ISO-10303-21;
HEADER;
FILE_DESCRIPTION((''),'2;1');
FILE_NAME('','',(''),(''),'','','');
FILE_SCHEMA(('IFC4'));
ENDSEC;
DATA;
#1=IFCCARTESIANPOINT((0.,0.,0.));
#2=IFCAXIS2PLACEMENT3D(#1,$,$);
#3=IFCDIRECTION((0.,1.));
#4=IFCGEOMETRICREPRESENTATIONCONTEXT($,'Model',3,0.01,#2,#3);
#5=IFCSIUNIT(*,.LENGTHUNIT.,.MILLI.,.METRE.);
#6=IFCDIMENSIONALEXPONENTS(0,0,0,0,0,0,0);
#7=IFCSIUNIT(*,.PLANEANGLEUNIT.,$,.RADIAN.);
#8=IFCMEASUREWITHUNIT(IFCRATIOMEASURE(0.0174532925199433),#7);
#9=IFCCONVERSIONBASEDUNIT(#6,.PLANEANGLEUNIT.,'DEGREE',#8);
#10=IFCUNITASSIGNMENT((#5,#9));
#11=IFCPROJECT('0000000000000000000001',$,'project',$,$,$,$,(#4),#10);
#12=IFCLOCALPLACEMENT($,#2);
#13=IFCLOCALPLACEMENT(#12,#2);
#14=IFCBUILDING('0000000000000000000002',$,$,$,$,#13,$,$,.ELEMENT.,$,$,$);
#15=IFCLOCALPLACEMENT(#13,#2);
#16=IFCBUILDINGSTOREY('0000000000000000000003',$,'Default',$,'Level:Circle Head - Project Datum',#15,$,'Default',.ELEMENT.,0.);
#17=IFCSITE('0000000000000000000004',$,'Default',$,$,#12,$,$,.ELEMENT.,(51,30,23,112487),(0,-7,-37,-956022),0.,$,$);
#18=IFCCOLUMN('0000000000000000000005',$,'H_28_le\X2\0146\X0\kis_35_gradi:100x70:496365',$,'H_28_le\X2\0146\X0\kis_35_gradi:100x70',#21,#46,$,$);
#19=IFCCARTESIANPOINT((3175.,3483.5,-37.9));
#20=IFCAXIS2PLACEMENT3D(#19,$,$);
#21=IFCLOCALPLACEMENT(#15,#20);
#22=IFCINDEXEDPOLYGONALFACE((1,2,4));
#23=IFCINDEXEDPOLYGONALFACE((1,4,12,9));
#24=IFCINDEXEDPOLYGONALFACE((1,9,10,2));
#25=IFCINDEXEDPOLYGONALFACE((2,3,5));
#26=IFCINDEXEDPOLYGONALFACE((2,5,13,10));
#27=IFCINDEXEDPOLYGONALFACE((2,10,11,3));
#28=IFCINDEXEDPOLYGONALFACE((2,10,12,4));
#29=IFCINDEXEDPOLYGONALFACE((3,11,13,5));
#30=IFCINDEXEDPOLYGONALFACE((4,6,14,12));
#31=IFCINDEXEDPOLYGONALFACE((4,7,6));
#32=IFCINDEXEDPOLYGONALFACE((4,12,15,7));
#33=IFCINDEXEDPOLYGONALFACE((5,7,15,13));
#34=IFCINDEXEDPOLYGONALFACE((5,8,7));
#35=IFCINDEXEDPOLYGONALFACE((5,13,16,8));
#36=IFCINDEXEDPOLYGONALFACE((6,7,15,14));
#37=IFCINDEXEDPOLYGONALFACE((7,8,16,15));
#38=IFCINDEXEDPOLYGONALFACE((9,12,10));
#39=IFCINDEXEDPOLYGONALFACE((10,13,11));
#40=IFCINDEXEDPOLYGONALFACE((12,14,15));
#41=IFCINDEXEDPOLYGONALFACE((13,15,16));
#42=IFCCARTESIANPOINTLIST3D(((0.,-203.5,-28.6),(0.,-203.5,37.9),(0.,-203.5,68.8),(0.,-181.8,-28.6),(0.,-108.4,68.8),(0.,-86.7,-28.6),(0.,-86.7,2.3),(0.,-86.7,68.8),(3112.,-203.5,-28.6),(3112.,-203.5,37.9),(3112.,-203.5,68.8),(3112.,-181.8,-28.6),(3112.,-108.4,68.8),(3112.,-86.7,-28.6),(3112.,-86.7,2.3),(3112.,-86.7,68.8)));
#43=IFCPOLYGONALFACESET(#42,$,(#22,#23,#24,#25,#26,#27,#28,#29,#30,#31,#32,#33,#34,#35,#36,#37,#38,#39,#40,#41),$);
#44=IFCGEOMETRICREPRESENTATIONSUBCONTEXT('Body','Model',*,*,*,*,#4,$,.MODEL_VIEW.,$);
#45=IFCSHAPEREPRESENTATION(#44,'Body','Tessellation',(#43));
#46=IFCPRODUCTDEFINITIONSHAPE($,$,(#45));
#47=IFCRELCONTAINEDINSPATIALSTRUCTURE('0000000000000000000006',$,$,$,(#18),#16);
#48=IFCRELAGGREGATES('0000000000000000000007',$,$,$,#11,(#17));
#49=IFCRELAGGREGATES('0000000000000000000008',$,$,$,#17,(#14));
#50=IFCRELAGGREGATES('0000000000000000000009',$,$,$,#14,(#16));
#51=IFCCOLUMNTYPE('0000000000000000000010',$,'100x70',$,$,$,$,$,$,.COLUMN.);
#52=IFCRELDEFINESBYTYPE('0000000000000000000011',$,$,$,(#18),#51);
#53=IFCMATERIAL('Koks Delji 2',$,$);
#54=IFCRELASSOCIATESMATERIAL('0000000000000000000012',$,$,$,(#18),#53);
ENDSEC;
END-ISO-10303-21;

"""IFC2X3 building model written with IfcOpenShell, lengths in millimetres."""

from ifc_helpers import new_model, entity, si_unit, converted_unit, direction, frame, frame_2d, origin, origin_2d_with_axis, place, context, subcontext, project, spatial, rectangle, extrude, boolean, source, transform, mapped, material, type_object, type_shapes, element, save


model = new_model("IFC2X3")

# Units and contexts
model_context = context("Model", 3, precision=0.01, world=origin(), true_north=direction((0.0, 1.0)))
body_context = subcontext(model_context, "Body", "Model", "MODEL_VIEW")
ifc_project = project(units=[si_unit("LENGTHUNIT", "METRE", prefix="MILLI"), converted_unit("PLANEANGLEUNIT", "DEGREE", entity("IfcRatioMeasure", 0.0174532925199433), si_unit("PLANEANGLEUNIT", "RADIAN"), dimensions=[0, 0, 0, 0, 0, 0, 0])], contexts=[model_context])

# Site, building, storey
site_placement = place(None, origin())
site = spatial("IfcSite", under=ifc_project, at=site_placement, Name="Default", CompositionType="ELEMENT", RefLatitude=(51, 30, 23, 112487), RefLongitude=(0, -7, -37, -956022), RefElevation=0.0)
building_placement = place(site_placement, origin())
building = spatial("IfcBuilding", under=site, at=building_placement, CompositionType="ELEMENT")
storey_placement = place(building_placement, origin())
storey = spatial("IfcBuildingStorey", under=building, at=storey_placement, Name="Default", ObjectType="Level:Circle Head - Project Datum", LongName="Default", CompositionType="ELEMENT", Elevation=0.0)

# Column
ifc_material_1 = material(Name="Koks Delji 2")
column_type_1 = type_object("IfcColumnType", Name="100x70", PredefinedType="COLUMN")
shared_shape_1 = source(origin(), body_context, "Body", "CSG", [
    boolean("DIFFERENCE", extrude(rectangle(XDim=3112.0, YDim=116.7, at=origin_2d_with_axis()), frame((1556.0, -145.1, -28.6)), (0.0, 0.0, 1.0), 97.5), extrude(rectangle(XDim=70.0, YDim=100.0, at=frame_2d((0.0, 0.0), x_axis=(0.0, 1.0))), frame((0.0, -145.1, 20.1), z_axis=(-1.0, 0.0, 0.0), x_axis=(0.0, -0.951057, -0.309017)), (0.0, 0.0, -1.0), 3112.0)),
])
type_shapes(column_type_1, [shared_shape_1])
column_placement = place(storey_placement, frame((3175.0, 3483.5, -37.9)))
element("IfcColumn", 1, at=column_placement, inside=storey, type_object=column_type_1, material=ifc_material_1, Name="H_28_leņkis_35_gradi:100x70:496365", ObjectType="H_28_leņkis_35_gradi:100x70", context=body_context, shape_type="MappedRepresentation", body=[
    mapped(shared_shape_1, transform((0.0, 0.0, 0.0), scale=1.0)),
])

save(model, "model.ifc")
